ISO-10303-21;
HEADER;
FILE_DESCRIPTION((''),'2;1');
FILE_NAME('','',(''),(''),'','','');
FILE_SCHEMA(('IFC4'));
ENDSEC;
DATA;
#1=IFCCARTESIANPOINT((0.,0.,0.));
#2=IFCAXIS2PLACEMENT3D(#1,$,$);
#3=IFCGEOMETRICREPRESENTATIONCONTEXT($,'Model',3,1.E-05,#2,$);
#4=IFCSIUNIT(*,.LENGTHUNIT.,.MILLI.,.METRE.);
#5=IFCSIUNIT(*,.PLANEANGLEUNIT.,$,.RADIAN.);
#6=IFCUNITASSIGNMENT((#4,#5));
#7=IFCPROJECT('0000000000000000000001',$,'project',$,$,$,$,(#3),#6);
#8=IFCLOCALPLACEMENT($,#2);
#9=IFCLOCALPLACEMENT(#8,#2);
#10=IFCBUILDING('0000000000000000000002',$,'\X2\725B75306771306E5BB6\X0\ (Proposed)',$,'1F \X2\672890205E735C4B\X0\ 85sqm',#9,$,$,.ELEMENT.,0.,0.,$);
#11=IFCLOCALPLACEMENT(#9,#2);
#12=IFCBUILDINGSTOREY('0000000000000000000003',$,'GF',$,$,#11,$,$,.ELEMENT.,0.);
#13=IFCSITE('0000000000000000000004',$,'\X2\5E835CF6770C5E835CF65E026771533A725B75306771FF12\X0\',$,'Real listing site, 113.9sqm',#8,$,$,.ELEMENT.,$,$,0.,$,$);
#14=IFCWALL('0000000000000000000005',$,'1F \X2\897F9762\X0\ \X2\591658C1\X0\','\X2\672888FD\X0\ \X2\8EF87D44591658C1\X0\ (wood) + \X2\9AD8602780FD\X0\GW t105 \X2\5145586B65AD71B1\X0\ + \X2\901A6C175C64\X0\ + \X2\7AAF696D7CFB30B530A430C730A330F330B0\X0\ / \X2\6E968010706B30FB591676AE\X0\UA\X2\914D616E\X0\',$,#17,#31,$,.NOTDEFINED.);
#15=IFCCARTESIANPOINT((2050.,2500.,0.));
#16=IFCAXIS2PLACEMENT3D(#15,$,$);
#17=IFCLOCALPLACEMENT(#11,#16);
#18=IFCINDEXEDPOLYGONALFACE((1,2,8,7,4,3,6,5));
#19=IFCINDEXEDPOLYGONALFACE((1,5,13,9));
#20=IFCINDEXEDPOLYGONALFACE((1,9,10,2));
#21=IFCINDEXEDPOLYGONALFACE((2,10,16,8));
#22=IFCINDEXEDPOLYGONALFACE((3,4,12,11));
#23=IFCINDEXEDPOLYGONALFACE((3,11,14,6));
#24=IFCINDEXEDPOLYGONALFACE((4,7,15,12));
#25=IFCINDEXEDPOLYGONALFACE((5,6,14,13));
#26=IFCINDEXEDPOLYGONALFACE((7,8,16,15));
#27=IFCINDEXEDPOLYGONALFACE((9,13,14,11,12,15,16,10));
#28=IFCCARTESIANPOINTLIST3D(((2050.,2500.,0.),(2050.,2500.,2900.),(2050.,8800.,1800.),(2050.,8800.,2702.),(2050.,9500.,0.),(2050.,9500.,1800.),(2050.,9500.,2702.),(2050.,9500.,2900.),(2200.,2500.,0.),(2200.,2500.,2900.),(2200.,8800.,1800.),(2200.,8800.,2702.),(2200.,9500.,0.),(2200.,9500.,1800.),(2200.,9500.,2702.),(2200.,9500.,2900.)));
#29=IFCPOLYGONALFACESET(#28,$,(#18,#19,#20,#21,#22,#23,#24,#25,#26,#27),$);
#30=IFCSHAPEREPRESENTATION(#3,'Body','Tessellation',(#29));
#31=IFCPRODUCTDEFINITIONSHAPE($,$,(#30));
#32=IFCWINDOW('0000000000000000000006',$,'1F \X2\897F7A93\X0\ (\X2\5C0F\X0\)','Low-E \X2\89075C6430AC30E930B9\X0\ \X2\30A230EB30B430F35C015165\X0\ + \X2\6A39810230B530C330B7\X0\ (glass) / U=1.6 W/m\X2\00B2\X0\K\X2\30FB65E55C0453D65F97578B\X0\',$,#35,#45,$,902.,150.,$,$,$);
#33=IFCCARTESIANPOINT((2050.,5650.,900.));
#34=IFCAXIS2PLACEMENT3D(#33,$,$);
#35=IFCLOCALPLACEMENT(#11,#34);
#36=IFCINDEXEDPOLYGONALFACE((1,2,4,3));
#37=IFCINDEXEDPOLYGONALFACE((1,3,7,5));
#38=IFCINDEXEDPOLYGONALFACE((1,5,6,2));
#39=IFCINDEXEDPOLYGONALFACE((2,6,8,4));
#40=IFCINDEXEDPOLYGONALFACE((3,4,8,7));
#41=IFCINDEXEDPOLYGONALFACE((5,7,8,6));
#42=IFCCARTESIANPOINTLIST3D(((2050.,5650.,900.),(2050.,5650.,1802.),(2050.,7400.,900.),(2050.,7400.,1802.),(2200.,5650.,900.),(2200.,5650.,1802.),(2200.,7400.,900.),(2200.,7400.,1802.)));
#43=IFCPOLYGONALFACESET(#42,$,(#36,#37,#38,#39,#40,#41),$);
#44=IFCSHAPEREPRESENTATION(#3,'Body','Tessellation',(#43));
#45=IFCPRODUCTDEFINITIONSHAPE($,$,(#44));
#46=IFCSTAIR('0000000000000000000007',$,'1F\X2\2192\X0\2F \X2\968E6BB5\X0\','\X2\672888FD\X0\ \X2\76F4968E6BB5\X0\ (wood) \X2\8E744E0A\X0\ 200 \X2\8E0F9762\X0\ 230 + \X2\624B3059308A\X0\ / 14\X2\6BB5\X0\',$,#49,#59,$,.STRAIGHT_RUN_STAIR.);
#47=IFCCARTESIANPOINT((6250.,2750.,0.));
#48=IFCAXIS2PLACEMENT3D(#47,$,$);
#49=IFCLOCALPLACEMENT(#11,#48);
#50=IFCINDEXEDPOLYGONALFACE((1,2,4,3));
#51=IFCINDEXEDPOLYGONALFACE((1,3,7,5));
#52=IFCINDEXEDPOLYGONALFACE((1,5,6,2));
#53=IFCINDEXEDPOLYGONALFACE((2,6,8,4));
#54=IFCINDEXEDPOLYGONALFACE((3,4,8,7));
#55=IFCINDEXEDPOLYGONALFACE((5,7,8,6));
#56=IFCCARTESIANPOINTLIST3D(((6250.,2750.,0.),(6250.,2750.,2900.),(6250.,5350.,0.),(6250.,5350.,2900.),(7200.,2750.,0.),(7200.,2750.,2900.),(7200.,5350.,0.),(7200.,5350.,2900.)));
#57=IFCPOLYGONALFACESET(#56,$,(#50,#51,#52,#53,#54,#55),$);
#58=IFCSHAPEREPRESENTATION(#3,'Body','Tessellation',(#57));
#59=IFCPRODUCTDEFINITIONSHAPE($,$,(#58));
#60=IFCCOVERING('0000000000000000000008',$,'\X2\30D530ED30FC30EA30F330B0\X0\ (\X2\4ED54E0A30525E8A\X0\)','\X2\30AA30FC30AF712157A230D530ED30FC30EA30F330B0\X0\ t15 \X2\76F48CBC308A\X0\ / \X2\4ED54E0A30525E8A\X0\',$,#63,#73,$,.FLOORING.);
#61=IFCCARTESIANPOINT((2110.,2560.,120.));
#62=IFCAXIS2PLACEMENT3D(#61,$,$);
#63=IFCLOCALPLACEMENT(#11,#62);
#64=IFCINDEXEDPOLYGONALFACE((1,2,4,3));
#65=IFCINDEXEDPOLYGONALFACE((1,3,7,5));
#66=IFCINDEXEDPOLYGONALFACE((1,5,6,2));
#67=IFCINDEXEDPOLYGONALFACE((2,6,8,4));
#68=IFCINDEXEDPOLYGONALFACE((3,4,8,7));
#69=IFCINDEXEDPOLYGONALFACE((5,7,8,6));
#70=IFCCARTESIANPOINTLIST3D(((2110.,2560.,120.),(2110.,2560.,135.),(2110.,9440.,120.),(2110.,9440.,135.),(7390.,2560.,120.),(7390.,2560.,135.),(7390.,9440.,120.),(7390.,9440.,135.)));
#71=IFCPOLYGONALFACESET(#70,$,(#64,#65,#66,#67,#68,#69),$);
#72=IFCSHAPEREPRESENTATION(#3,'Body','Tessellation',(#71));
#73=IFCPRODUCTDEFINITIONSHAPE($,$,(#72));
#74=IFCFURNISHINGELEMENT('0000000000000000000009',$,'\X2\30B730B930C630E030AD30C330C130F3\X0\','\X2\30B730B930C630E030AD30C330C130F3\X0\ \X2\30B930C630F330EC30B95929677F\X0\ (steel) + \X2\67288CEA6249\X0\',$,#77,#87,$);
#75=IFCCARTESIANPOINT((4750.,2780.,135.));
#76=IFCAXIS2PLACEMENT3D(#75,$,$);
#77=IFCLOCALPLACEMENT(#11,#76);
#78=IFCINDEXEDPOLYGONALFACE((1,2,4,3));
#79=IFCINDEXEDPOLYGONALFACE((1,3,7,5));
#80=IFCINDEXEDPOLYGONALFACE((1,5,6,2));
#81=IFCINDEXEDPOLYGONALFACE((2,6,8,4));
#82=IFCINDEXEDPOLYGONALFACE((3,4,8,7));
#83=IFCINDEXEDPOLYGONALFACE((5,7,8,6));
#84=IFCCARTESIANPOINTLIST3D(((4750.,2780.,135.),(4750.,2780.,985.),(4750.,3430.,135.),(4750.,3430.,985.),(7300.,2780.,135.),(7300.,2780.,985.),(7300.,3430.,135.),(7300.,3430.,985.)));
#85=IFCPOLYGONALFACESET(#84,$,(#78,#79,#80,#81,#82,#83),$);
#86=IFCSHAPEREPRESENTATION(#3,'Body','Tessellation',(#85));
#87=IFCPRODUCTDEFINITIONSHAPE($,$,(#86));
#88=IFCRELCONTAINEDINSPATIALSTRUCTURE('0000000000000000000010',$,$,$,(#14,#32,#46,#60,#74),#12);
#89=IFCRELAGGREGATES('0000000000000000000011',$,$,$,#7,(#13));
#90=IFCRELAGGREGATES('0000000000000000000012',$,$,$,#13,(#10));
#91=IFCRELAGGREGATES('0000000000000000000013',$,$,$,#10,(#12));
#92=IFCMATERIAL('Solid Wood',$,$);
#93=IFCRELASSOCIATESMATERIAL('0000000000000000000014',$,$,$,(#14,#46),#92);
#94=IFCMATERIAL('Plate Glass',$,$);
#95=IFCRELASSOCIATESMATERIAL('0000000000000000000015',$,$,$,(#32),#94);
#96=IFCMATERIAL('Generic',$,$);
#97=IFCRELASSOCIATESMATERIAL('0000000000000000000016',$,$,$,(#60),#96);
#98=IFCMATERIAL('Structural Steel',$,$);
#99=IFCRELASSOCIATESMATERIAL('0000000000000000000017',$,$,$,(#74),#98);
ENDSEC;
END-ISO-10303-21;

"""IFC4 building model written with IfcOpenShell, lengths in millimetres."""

from ifc_helpers import new_model, si_unit, frame, frame_2d, origin, place, context, project, spatial, rectangle, extrude, material, element, fill, save


model = new_model("IFC4")

# Units and contexts
model_context = context("Model", 3, precision=1e-05, world=origin())
ifc_project = project(units=[si_unit("LENGTHUNIT", "METRE", prefix="MILLI"), si_unit("PLANEANGLEUNIT", "RADIAN")], contexts=[model_context])

# Site, building, storey
site_placement = place(None, origin())
site = spatial("IfcSite", under=ifc_project, at=site_placement, Name="広島県広島市東区牛田東２", ObjectType="Real listing site, 113.9sqm", CompositionType="ELEMENT", RefElevation=0.0)
building_placement = place(site_placement, origin())
building = spatial("IfcBuilding", under=site, at=building_placement, Name="牛田東の家 (Proposed)", ObjectType="1F 木造平屋 85sqm", CompositionType="ELEMENT", ElevationOfRefHeight=0.0, ElevationOfTerrain=0.0)
storey_placement = place(building_placement, origin())
storey = spatial("IfcBuildingStorey", under=building, at=storey_placement, Name="GF", CompositionType="ELEMENT", Elevation=0.0)

# Shared definitions
ifc_material_1 = material(Name="Solid Wood")
ifc_material_2 = material(Name="Generic")

# Shared definitions
ifc_material_3 = material(Name="Plate Glass")

# Wall, opening, window
wall_1_placement = place(storey_placement, frame((2050.0, 2500.0, 0.0)))
wall_1 = element("IfcWall", 1, at=wall_1_placement, inside=storey, material=ifc_material_1, Name="1F 西面 外壁", Description="木製 軸組外壁 (wood) + 高性能GW t105 充填断熱 + 通気層 + 窯業系サイディング / 準耐火・外皮UA配慮", PredefinedType="NOTDEFINED", context=model_context, shape_type="SweptSolid", body=[
    extrude(rectangle(XDim=150.0, YDim=7000.0, at=frame_2d((75.0, 3500.0))), frame((2050.0, 2500.0, 0.0)), (0.0, 0.0, 1.0), 2900.0),
])
opening_1_placement = place(storey_placement, frame((2050.0, 5650.0, 900.0)))
opening_1 = element("IfcOpeningElement", 2, at=opening_1_placement, cuts=wall_1, PredefinedType="NOTDEFINED", context=model_context, shape_type="SweptSolid", body=[
    extrude(rectangle(XDim=150.0, YDim=1750.0, at=frame_2d((75.0, 875.0))), frame((2050.0, 5650.0, 900.0)), (0.0, 0.0, 1.0), 902.0),
])
window_1_placement = place(storey_placement, frame((2050.0, 5650.0, 900.0)))
window_1 = element("IfcWindow", 3, at=window_1_placement, inside=storey, material=ifc_material_3, Name="1F 西窓 (小)", Description="Low-E 複層ガラス アルゴン封入 + 樹脂サッシ (glass) / U=1.6 W/m²K・日射取得型", OverallHeight=902.0, OverallWidth=150.0, context=model_context, shape_type="SweptSolid", body=[
    extrude(rectangle(XDim=150.0, YDim=1750.0, at=frame_2d((75.0, 875.0))), frame((2050.0, 5650.0, 900.0)), (0.0, 0.0, 1.0), 902.0),
])
fill(opening_1, window_1)

# Stair
stair_placement = place(storey_placement, frame((6250.0, 2750.0, 0.0)))
element("IfcStair", 4, at=stair_placement, inside=storey, material=ifc_material_1, Name="1F→2F 階段", Description="木製 直階段 (wood) 蹴上 200 踏面 230 + 手すり / 14段", PredefinedType="STRAIGHT_RUN_STAIR", context=model_context, shape_type="SweptSolid", body=[
    extrude(rectangle(XDim=950.0, YDim=2600.0, at=frame_2d((475.0, 1300.0))), frame((6250.0, 2750.0, 0.0)), (0.0, 0.0, 1.0), 2900.0),
])

# Covering
covering_placement = place(storey_placement, frame((2110.0, 2560.0, 120.0)))
element("IfcCovering", 5, at=covering_placement, inside=storey, material=ifc_material_2, Name="フローリング (仕上げ床)", Description="オーク無垢フローリング t15 直貼り / 仕上げ床", PredefinedType="FLOORING", context=model_context, shape_type="SweptSolid", body=[
    extrude(rectangle(XDim=5280.0, YDim=6880.0, at=frame_2d((2640.0, 3440.0))), frame((2110.0, 2560.0, 120.0)), (0.0, 0.0, 1.0), 15.0),
])

# Furnishing element
ifc_material_4 = material(Name="Structural Steel")
furnishing_placement = place(storey_placement, frame((4750.0, 2780.0, 135.0)))
element("IfcFurnishingElement", 6, at=furnishing_placement, inside=storey, material=ifc_material_4, Name="システムキッチン", Description="システムキッチン ステンレス天板 (steel) + 木質扉", context=model_context, shape_type="SweptSolid", body=[
    extrude(rectangle(XDim=2550.0, YDim=650.0, at=frame_2d((1275.0, 325.0))), frame((4750.0, 2780.0, 135.0)), (0.0, 0.0, 1.0), 850.0),
])

save(model, "model.ifc")
